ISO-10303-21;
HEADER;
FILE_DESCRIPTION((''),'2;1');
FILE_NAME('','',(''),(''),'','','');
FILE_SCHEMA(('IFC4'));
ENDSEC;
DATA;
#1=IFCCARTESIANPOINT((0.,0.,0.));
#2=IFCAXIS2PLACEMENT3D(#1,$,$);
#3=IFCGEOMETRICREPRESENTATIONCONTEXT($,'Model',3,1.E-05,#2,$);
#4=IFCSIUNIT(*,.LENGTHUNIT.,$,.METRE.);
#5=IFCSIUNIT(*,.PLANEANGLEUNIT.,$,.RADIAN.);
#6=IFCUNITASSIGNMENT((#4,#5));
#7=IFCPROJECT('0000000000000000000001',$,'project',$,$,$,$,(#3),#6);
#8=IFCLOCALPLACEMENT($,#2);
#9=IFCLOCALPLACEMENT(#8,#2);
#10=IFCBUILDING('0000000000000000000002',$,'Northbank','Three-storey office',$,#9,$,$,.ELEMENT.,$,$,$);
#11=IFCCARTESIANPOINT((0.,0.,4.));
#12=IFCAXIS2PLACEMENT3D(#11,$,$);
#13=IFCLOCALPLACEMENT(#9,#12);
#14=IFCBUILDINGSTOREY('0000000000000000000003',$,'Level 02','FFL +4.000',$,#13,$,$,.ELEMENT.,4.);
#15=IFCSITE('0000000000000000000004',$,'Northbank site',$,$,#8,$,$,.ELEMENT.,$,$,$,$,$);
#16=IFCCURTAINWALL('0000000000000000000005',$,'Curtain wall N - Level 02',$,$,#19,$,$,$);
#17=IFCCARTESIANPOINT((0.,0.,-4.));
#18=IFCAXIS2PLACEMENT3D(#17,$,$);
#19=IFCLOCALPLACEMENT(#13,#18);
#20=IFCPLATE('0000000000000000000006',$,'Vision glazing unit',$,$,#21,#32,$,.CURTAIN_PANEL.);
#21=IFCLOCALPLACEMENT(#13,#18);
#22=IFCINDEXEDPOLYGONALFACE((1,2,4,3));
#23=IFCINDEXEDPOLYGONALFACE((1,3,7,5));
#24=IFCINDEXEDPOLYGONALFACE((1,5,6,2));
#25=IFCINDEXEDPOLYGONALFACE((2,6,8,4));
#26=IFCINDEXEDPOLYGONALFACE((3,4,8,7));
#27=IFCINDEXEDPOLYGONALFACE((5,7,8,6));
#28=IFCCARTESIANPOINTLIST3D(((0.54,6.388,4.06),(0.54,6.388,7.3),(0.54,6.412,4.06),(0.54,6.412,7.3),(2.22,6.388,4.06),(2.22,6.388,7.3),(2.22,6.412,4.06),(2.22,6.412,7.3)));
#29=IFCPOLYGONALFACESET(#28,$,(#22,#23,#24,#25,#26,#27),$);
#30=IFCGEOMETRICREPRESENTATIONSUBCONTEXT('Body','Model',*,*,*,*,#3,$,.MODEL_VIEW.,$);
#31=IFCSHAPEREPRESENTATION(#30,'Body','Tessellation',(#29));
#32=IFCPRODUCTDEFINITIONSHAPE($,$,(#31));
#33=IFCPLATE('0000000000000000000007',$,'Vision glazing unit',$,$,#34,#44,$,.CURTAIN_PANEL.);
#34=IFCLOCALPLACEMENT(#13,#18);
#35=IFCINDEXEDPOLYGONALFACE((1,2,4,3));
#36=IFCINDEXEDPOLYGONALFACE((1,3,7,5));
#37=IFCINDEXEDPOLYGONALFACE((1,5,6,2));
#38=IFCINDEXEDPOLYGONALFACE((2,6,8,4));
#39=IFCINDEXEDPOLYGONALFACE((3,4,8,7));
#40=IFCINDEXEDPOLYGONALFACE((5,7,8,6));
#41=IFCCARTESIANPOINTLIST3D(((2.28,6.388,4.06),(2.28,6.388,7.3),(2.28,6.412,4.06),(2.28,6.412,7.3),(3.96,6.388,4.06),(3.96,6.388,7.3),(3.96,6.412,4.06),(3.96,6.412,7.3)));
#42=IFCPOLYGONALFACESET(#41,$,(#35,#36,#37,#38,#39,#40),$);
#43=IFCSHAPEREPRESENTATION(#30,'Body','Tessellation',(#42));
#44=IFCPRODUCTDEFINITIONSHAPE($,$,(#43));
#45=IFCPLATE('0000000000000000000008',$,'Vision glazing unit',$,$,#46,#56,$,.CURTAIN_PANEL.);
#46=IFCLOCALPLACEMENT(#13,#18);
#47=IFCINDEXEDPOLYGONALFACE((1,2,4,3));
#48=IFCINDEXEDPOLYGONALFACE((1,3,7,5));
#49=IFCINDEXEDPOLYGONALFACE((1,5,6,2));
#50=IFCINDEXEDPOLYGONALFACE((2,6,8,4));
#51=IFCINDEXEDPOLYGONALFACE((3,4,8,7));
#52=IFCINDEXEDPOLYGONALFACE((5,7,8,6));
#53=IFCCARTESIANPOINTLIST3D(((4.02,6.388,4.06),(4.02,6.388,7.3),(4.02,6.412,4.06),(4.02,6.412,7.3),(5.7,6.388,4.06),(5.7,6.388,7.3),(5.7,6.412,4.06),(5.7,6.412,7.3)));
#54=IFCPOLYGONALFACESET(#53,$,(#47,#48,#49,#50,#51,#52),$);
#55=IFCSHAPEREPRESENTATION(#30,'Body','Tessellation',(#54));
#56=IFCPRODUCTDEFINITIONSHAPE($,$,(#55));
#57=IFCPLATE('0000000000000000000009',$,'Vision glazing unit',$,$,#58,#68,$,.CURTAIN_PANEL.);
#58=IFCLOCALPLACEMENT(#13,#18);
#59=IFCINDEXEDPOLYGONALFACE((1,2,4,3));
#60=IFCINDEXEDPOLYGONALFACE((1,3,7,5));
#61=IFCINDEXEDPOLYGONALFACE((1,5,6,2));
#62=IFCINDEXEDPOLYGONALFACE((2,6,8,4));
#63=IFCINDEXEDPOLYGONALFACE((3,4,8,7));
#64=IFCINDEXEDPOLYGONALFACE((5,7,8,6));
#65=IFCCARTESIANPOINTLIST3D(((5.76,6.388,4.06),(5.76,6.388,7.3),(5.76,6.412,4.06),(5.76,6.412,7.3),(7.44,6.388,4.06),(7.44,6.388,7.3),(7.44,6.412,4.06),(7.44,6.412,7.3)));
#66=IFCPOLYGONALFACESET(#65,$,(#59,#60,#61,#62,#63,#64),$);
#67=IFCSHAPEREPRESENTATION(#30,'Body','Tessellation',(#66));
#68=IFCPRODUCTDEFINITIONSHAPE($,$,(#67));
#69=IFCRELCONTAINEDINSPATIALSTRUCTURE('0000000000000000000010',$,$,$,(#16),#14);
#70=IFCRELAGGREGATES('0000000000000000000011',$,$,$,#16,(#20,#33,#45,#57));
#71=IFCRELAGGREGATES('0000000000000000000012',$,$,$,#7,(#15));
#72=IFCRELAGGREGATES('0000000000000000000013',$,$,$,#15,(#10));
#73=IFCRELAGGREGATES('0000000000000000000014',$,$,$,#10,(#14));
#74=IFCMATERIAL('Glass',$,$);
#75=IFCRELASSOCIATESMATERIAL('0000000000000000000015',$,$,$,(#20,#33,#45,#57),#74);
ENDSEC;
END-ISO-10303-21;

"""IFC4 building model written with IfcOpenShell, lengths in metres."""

from ifc_helpers import new_model, si_unit, frame, origin, place, context, subcontext, project, spatial, rectangle, extrude, material, element, aggregate, save


model = new_model("IFC4")

# Units and contexts
model_context = context("Model", 3, precision=1e-05, world=origin())
body_context = subcontext(model_context, "Body", "Model", "MODEL_VIEW")
ifc_project = project(units=[si_unit("LENGTHUNIT", "METRE"), si_unit("PLANEANGLEUNIT", "RADIAN")], contexts=[model_context])

# Site, building, storey
site_placement = place(None, origin())
site = spatial("IfcSite", under=ifc_project, at=site_placement, Name="Northbank site", CompositionType="ELEMENT")
building_placement = place(site_placement, origin())
building = spatial("IfcBuilding", under=site, at=building_placement, Name="Northbank", Description="Three-storey office", CompositionType="ELEMENT")
storey_placement = place(building_placement, frame((0.0, 0.0, 4.0)))
storey = spatial("IfcBuildingStorey", under=building, at=storey_placement, Name="Level 02", Description="FFL +4.000", CompositionType="ELEMENT", Elevation=4.0)

# Curtain wall, plates
curtain_wall_placement = place(storey_placement, frame((0.0, 0.0, -4.0)))
curtain_wall = element("IfcCurtainWall", 1, at=curtain_wall_placement, inside=storey, Name="Curtain wall N - Level 02")
ifc_material_1 = material(Name="Glass")
plate_1_placement = place(storey_placement, frame((0.0, 0.0, -4.0)))
plate_1 = element("IfcPlate", 2, at=plate_1_placement, material=ifc_material_1, Name="Vision glazing unit", PredefinedType="CURTAIN_PANEL", context=body_context, shape_type="SweptSolid", body=[
    extrude(rectangle(XDim=1.68, YDim=0.024), frame((1.38, 6.4, 4.06)), (0.0, 0.0, 1.0), 3.24),
])
plate_2_placement = place(storey_placement, frame((0.0, 0.0, -4.0)))
plate_2 = element("IfcPlate", 3, at=plate_2_placement, material=ifc_material_1, Name="Vision glazing unit", PredefinedType="CURTAIN_PANEL", context=body_context, shape_type="SweptSolid", body=[
    extrude(rectangle(XDim=1.68, YDim=0.024), frame((3.12, 6.4, 4.06)), (0.0, 0.0, 1.0), 3.24),
])
plate_3_placement = place(storey_placement, frame((0.0, 0.0, -4.0)))
plate_3 = element("IfcPlate", 4, at=plate_3_placement, material=ifc_material_1, Name="Vision glazing unit", PredefinedType="CURTAIN_PANEL", context=body_context, shape_type="SweptSolid", body=[
    extrude(rectangle(XDim=1.68, YDim=0.024), frame((4.86, 6.4, 4.06)), (0.0, 0.0, 1.0), 3.24),
])
plate_4_placement = place(storey_placement, frame((0.0, 0.0, -4.0)))
plate_4 = element("IfcPlate", 5, at=plate_4_placement, material=ifc_material_1, Name="Vision glazing unit", PredefinedType="CURTAIN_PANEL", context=body_context, shape_type="SweptSolid", body=[
    extrude(rectangle(XDim=1.68, YDim=0.024), frame((6.6, 6.4, 4.06)), (0.0, 0.0, 1.0), 3.24),
])
aggregate(curtain_wall, [plate_1, plate_2, plate_3, plate_4])

save(model, "model.ifc")
